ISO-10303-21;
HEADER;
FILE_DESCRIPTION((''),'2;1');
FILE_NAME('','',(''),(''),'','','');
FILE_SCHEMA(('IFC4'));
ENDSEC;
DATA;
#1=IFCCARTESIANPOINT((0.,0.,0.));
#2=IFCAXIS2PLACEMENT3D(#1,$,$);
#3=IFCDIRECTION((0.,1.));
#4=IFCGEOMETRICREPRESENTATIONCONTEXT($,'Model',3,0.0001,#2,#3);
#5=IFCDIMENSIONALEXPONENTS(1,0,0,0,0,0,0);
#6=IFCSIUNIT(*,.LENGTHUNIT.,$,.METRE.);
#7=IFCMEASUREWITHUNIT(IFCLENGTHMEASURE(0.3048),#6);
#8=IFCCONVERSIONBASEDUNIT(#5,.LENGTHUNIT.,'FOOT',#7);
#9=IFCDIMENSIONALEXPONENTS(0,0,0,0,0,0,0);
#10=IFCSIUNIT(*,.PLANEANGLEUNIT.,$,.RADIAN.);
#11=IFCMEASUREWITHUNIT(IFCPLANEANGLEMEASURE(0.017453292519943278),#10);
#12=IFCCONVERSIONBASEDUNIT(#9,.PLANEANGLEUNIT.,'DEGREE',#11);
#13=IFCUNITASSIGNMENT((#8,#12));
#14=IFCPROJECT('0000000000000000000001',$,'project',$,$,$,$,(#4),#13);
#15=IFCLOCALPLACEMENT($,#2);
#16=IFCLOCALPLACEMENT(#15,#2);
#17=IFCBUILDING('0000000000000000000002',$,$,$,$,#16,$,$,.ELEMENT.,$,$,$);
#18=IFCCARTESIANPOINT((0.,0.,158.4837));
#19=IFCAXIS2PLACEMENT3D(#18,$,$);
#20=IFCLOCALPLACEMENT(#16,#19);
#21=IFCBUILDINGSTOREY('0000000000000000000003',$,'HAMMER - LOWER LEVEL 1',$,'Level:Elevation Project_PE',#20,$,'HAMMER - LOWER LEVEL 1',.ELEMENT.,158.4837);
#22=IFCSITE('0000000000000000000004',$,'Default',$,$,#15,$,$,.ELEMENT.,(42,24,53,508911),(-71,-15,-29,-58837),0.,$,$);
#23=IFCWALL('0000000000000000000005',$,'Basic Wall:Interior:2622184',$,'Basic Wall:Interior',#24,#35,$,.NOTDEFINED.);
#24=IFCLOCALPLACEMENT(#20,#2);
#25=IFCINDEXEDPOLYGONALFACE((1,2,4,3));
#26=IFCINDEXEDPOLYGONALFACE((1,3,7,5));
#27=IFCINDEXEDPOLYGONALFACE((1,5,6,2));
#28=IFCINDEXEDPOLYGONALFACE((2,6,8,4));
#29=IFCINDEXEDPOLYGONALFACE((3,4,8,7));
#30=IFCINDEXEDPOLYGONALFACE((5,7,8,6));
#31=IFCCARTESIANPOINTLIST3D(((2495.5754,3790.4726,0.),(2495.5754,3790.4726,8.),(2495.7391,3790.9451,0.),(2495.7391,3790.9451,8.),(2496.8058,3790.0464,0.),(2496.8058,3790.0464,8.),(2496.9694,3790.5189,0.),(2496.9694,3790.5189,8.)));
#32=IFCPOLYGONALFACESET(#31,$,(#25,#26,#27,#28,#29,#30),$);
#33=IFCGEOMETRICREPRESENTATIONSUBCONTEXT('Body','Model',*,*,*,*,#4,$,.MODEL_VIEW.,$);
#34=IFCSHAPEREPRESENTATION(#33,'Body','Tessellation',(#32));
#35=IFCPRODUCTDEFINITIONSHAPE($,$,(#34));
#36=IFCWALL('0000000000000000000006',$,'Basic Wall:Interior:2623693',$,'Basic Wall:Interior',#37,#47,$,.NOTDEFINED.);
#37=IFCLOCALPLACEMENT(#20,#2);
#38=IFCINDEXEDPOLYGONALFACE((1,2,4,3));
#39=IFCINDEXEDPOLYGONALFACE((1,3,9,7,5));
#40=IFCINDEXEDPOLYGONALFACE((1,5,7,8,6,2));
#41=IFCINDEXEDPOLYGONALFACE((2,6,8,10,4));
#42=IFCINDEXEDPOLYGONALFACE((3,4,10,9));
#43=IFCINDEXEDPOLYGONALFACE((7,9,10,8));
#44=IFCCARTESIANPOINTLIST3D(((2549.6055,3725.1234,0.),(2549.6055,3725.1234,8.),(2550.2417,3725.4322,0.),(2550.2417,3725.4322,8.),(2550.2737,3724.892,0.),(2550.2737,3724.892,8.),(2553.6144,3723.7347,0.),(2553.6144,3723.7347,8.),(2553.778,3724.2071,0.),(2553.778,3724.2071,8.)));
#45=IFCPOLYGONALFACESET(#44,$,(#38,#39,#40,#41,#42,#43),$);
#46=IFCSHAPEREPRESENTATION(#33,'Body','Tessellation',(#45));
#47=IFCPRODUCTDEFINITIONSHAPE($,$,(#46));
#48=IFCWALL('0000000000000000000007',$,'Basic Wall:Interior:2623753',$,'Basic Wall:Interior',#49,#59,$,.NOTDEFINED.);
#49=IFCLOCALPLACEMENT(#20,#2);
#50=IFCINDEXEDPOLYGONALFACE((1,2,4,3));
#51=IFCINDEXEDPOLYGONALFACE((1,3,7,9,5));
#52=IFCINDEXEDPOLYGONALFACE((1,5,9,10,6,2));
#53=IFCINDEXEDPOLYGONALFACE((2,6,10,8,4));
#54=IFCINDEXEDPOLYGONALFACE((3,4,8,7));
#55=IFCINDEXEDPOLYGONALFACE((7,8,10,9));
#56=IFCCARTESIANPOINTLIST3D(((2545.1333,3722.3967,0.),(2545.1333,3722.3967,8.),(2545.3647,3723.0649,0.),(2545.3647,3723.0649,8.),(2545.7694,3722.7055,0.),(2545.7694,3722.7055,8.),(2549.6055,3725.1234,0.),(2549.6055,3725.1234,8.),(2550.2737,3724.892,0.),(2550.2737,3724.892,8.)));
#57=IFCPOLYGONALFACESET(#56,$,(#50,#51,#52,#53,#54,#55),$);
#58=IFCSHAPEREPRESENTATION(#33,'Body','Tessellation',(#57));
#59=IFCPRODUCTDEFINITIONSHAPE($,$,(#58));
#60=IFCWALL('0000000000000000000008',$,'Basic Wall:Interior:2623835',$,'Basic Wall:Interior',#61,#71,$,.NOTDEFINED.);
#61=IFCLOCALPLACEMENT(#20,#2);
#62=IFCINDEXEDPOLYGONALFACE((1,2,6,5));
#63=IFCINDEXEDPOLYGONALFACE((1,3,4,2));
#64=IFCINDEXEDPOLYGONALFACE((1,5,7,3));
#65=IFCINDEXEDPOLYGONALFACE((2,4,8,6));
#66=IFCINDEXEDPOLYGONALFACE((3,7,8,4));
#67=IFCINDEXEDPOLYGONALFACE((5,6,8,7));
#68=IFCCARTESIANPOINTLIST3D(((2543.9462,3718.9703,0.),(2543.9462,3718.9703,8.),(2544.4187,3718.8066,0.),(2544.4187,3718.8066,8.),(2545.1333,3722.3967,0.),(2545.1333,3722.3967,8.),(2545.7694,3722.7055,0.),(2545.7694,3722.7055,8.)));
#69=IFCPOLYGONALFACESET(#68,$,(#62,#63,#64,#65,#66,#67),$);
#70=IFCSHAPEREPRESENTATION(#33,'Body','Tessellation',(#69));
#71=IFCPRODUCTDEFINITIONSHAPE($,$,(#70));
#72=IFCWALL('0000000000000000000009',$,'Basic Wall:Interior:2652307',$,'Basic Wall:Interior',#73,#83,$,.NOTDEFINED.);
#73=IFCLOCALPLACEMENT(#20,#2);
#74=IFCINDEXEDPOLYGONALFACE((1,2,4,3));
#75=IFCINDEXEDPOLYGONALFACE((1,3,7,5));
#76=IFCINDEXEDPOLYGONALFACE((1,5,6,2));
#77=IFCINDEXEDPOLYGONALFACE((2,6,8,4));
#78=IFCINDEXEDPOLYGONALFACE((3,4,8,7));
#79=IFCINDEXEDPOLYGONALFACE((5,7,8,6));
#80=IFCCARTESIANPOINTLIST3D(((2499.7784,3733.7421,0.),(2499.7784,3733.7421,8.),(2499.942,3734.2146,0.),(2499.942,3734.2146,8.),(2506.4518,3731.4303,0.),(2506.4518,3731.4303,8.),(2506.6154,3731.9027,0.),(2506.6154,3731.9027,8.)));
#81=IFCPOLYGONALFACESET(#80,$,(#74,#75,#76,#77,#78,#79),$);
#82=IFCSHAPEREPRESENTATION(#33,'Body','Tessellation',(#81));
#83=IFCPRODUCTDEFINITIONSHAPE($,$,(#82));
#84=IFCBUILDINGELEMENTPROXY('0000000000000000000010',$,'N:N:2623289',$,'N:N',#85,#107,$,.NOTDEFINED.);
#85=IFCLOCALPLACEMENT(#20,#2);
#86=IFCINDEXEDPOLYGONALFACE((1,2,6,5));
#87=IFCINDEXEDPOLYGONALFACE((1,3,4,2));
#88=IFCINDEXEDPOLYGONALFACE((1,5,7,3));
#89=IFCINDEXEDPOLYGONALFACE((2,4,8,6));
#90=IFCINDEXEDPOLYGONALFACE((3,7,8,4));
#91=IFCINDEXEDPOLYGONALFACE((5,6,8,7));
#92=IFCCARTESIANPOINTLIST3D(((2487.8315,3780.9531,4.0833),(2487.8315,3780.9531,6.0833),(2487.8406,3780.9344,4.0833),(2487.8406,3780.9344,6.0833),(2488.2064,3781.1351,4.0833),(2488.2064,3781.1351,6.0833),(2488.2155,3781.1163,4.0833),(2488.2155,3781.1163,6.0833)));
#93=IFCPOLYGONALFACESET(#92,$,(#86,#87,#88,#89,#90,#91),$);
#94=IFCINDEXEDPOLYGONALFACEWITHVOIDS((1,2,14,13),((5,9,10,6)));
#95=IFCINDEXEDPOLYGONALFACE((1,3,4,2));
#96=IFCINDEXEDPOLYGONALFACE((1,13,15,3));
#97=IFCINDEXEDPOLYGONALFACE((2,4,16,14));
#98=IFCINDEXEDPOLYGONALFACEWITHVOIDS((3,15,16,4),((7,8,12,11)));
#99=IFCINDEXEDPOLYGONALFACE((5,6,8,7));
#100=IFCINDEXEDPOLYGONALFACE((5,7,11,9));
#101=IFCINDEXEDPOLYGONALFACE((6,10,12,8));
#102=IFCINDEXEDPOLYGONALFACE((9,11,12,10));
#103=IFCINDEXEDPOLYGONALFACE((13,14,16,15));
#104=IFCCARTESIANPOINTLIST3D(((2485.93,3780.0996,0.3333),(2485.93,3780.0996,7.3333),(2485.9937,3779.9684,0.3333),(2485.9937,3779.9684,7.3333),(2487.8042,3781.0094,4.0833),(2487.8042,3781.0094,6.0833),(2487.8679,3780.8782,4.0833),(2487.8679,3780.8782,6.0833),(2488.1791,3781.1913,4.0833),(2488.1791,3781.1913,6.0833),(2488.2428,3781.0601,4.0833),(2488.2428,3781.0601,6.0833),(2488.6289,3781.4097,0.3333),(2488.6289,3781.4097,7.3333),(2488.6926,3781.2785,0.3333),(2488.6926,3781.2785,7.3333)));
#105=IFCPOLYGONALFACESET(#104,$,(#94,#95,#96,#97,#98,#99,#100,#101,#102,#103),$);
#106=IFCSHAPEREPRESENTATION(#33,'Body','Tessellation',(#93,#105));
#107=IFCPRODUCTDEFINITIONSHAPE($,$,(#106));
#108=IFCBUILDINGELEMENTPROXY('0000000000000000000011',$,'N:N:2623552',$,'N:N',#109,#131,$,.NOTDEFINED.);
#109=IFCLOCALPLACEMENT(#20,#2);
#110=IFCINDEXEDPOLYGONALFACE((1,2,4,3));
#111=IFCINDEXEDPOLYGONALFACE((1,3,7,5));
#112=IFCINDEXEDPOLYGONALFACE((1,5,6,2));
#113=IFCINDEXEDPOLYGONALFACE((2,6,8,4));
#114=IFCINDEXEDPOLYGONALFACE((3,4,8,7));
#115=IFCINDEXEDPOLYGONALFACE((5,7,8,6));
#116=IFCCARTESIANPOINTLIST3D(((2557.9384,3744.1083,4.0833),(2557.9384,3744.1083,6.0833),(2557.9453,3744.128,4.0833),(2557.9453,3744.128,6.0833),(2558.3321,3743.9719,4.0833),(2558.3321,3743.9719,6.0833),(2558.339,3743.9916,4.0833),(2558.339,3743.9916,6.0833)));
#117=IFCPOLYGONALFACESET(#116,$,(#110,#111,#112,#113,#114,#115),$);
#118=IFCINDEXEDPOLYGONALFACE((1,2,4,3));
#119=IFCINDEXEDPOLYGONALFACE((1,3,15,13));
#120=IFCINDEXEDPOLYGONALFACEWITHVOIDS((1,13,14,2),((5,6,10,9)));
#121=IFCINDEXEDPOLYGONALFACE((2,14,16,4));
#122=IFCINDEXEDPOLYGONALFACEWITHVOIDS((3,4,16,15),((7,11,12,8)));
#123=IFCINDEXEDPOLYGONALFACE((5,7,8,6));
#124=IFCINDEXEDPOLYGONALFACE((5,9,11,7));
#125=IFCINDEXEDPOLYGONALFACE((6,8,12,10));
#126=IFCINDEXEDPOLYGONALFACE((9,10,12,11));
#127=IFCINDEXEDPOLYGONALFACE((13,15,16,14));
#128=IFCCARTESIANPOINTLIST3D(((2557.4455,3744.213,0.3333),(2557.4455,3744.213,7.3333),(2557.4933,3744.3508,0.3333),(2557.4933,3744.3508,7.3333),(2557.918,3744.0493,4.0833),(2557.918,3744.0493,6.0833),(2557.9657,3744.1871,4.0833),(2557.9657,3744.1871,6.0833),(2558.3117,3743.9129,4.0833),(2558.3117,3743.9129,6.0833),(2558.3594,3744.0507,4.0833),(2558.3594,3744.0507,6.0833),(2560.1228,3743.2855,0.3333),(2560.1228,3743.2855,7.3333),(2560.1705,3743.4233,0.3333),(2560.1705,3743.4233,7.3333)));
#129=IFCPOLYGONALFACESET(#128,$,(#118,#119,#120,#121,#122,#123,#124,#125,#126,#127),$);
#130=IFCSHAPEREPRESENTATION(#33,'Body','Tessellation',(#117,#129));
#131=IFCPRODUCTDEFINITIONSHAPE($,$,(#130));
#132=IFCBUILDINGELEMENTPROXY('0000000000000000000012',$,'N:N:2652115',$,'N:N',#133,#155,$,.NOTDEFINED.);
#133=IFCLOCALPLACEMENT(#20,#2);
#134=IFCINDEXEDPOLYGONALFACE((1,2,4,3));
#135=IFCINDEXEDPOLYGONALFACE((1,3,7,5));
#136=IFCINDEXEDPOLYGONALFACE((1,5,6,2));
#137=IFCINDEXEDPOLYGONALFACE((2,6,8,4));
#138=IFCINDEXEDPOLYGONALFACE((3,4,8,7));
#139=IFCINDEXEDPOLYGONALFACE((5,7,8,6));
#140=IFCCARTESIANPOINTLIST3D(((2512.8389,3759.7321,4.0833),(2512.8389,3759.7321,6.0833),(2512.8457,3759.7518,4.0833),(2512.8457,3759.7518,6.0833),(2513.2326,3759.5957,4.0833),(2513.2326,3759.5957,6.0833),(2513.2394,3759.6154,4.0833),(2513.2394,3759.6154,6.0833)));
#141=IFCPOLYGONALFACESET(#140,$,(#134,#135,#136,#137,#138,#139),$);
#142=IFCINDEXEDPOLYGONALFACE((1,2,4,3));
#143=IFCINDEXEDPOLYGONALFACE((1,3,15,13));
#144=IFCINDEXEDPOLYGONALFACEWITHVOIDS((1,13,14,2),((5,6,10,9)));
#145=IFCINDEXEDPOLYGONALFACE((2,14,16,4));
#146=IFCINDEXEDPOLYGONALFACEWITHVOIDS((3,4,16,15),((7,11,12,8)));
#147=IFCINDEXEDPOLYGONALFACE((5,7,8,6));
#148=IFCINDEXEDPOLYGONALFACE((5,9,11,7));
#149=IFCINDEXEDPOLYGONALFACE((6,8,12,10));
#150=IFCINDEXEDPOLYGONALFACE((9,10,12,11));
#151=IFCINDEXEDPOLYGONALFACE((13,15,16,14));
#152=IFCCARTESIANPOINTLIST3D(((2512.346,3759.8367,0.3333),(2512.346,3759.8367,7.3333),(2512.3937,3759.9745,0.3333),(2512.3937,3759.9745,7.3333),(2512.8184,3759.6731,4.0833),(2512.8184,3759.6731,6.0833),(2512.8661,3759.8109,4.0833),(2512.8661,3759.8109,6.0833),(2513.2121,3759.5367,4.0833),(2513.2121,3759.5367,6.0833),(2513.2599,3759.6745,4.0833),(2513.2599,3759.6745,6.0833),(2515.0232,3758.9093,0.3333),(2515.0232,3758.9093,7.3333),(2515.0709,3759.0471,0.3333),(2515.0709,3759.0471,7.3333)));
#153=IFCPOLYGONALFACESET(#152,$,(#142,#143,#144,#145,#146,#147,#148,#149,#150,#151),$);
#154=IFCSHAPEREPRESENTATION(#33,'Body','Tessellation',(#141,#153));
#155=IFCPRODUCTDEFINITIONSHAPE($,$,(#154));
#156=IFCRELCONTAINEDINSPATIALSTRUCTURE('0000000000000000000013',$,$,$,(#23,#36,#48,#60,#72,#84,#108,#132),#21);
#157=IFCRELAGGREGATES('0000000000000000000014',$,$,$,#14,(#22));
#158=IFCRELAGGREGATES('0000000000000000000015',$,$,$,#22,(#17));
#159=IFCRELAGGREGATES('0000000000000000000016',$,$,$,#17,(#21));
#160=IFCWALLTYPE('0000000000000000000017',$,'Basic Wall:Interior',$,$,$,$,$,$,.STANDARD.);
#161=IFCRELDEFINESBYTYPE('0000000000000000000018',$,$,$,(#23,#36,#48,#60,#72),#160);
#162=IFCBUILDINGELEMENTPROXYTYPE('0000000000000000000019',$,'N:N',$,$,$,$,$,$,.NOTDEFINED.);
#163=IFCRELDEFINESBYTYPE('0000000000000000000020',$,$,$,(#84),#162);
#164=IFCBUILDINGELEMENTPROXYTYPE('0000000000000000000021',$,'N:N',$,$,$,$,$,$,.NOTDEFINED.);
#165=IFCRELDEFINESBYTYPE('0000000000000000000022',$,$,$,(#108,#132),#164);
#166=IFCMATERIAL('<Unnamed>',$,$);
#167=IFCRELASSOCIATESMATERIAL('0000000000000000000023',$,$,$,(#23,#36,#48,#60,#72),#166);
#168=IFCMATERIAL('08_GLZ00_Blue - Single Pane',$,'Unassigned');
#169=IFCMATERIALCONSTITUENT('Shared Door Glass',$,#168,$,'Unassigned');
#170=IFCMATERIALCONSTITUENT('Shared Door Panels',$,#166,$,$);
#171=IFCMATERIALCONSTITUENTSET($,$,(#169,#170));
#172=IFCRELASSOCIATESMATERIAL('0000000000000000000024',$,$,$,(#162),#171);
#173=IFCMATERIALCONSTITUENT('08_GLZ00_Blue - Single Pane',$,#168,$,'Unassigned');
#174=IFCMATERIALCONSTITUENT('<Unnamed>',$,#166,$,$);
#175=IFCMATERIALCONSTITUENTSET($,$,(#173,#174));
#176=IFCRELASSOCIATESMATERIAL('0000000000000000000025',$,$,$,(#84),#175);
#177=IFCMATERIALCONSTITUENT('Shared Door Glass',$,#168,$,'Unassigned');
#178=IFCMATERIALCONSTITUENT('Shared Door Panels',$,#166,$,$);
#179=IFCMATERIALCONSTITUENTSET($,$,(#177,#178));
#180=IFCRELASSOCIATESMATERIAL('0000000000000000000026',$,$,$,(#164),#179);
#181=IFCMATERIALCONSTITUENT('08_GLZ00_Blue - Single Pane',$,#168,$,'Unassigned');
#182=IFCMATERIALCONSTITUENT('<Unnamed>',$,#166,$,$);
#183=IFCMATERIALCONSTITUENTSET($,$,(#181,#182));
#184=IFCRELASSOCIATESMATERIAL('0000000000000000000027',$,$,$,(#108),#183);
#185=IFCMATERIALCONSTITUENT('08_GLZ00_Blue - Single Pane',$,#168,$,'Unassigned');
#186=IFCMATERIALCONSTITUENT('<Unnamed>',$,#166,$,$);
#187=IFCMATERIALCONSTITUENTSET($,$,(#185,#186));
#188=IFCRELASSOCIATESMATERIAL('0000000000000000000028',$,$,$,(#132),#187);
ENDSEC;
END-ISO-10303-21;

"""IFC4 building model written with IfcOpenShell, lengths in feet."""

from ifc_helpers import new_model, entity, si_unit, converted_unit, direction, frame, origin, place, context, subcontext, project, spatial, indexed_curve, outline, extrude, source, transform, mapped, material, constituent, constituent_set, type_object, type_shapes, element, save


model = new_model("IFC4")

# Units and contexts
model_context = context("Model", 3, precision=0.0001, world=origin(), true_north=direction((0.0, 1.0)))
body_context = subcontext(model_context, "Body", "Model", "MODEL_VIEW")
ifc_project = project(units=[converted_unit("LENGTHUNIT", "FOOT", entity("IfcLengthMeasure", 0.3048), si_unit("LENGTHUNIT", "METRE"), dimensions=[1, 0, 0, 0, 0, 0, 0]), converted_unit("PLANEANGLEUNIT", "DEGREE", entity("IfcPlaneAngleMeasure", 0.017453292519943278), si_unit("PLANEANGLEUNIT", "RADIAN"), dimensions=[0, 0, 0, 0, 0, 0, 0])], contexts=[model_context])

# Site, building, storey
site_placement = place(None, origin())
site = spatial("IfcSite", under=ifc_project, at=site_placement, Name="Default", CompositionType="ELEMENT", RefLatitude=(42, 24, 53, 508911), RefLongitude=(-71, -15, -29, -58837), RefElevation=0.0)
building_placement = place(site_placement, origin())
building = spatial("IfcBuilding", under=site, at=building_placement, CompositionType="ELEMENT")
storey_placement = place(building_placement, frame((0.0, 0.0, 158.4837)))
storey = spatial("IfcBuildingStorey", under=building, at=storey_placement, Name="HAMMER - LOWER LEVEL 1", ObjectType="Level:Elevation Project_PE", LongName="HAMMER - LOWER LEVEL 1", CompositionType="ELEMENT", Elevation=158.4837)

# Walls
ifc_material_1 = material(Name="<Unnamed>")
wall_type = type_object("IfcWallType", Name="Basic Wall:Interior", PredefinedType="STANDARD")
wall_1_placement = place(storey_placement, frame((2495.6573, 3790.7089, 0.0), z_axis=(0.0, 0.0, 1.0), x_axis=(0.944906, -0.327342, 0.0)))
element("IfcWall", 1, at=wall_1_placement, inside=storey, type_object=wall_type, material=ifc_material_1, Name="Basic Wall:Interior:2622184", ObjectType="Basic Wall:Interior", PredefinedType="NOTDEFINED", context=body_context, shape_type="SweptSolid", body=[
    extrude(outline(indexed_curve([(1.3021, 0.25), (0.0, 0.25), (0.0, -0.25), (1.3021, -0.25), (1.3021, 0.25)], self_intersect=False)), origin(), (0.0, 0.0, 1.0), 8.0),
])
wall_2_placement = place(storey_placement, frame((2553.6962, 3723.9709, 0.0), z_axis=(0.0, 0.0, 1.0), x_axis=(-0.944906, 0.327342, 0.0)))
element("IfcWall", 2, at=wall_2_placement, inside=storey, type_object=wall_type, material=ifc_material_1, Name="Basic Wall:Interior:2623693", ObjectType="Basic Wall:Interior", PredefinedType="NOTDEFINED", context=body_context, shape_type="SweptSolid", body=[
    extrude(outline(indexed_curve([(3.7426, -0.25), (4.2426, 0.25), (3.5355, 0.25), (0.0, 0.25), (0.0, -0.25), (3.7426, -0.25)], self_intersect=False)), origin(), (0.0, 0.0, 1.0), 8.0),
])
wall_3_placement = place(storey_placement, frame((2550.1645, 3725.1169, 0.0), z_axis=(0.0, 0.0, 1.0), x_axis=(-0.899615, -0.436683, 0.0)))
element("IfcWall", 3, at=wall_3_placement, inside=storey, type_object=wall_type, material=ifc_material_1, Name="Basic Wall:Interior:2623753", ObjectType="Basic Wall:Interior", PredefinedType="NOTDEFINED", context=body_context, shape_type="SweptSolid", body=[
    extrude(outline(indexed_curve([(5.214, -0.25), (5.714, 0.25), (5.0069, 0.25), (0.0, 0.25), (0.5, -0.25), (5.214, -0.25)], self_intersect=False)), origin(), (0.0, 0.0, 1.0), 8.0),
])
wall_4_placement = place(storey_placement, frame((2545.5332, 3722.7873, 0.0), z_axis=(0.0, 0.0, 1.0), x_axis=(-0.327342, -0.944906, 0.0)))
element("IfcWall", 4, at=wall_4_placement, inside=storey, type_object=wall_type, material=ifc_material_1, Name="Basic Wall:Interior:2623835", ObjectType="Basic Wall:Interior", PredefinedType="NOTDEFINED", context=body_context, shape_type="SweptSolid", body=[
    extrude(outline(indexed_curve([(4.1262, -0.25), (4.1262, 0.25), (0.0, 0.25), (0.5, -0.25), (4.1262, -0.25)], self_intersect=False)), origin(), (0.0, 0.0, 1.0), 8.0),
])
wall_5_placement = place(storey_placement, frame((2506.5336, 3731.6665, 0.0), z_axis=(0.0, 0.0, 1.0), x_axis=(-0.944906, 0.327342, 0.0)))
element("IfcWall", 5, at=wall_5_placement, inside=storey, type_object=wall_type, material=ifc_material_1, Name="Basic Wall:Interior:2652307", ObjectType="Basic Wall:Interior", PredefinedType="NOTDEFINED", context=body_context, shape_type="SweptSolid", body=[
    extrude(outline(indexed_curve([(7.0625, 0.25), (0.0, 0.25), (0.0, -0.25), (7.0625, -0.25), (7.0625, 0.25)], self_intersect=False)), origin(), (0.0, 0.0, 1.0), 8.0),
])

# Building element proxies
ifc_material_2 = material(Name="08_GLZ00_Blue - Single Pane", Category="Unassigned")
ifc_constituent_1 = constituent(ifc_material_2, Name="08_GLZ00_Blue - Single Pane", Category="Unassigned")
ifc_constituent_2 = constituent(ifc_material_1, Name="<Unnamed>")
ifc_constituent_set_1 = constituent_set(constituents=[ifc_constituent_1, ifc_constituent_2])
ifc_constituent_3 = constituent(ifc_material_2, Name="Shared Door Glass", Category="Unassigned")
ifc_constituent_4 = constituent(ifc_material_1, Name="Shared Door Panels")
ifc_constituent_set_2 = constituent_set(constituents=[ifc_constituent_3, ifc_constituent_4])
building_element_proxy_type_1 = type_object("IfcBuildingElementProxyType", Name="N:N", PredefinedType="NOTDEFINED", material=ifc_constituent_set_2)
shared_shape_1 = source(origin(), body_context, "Body", "SweptSolid", [
    extrude(outline(indexed_curve([(-0.2083, -0.0104), (0.2083, -0.0104), (0.2083, 0.0104), (-0.2083, 0.0104), (-0.2083, -0.0104)], self_intersect=False)), frame((-1.0775, -3.25, 3.75), z_axis=(0.0, 0.0, 1.0), x_axis=(-1.0, 0.0, 0.0)), (0.0, 0.0, 1.0), 2.0),
    extrude(outline(indexed_curve([(-3.5, -1.5), (3.5, -1.5), (3.5, 1.5), (-3.5, 1.5), (-3.5, -1.5)], self_intersect=False), holes=[indexed_curve([(-2.25, 0.5833), (-2.25, 1.0), (-0.25, 1.0), (-0.25, 0.5833), (-2.25, 0.5833)], self_intersect=False)]), frame((-0.2859, -3.3229, 3.5), z_axis=(0.0, 1.0, 0.0), x_axis=(0.0, 0.0, -1.0)), (0.0, 0.0, 1.0), 0.1458),
])
type_shapes(building_element_proxy_type_1, [shared_shape_1])
proxy_1_placement = place(storey_placement, frame((2488.4733, 3777.6404, 0.3333), z_axis=(0.0, 0.0, 1.0), x_axis=(-0.899615, -0.436683, 0.0)))
element("IfcBuildingElementProxy", 6, at=proxy_1_placement, inside=storey, type_object=building_element_proxy_type_1, material=ifc_constituent_set_1, Name="N:N:2623289", ObjectType="N:N", PredefinedType="NOTDEFINED", context=body_context, shape_type="MappedRepresentation", body=[
    mapped(shared_shape_1, transform((0.0, 0.0, 0.0), scale=1.0)),
])
ifc_constituent_5 = constituent(ifc_material_2, Name="08_GLZ00_Blue - Single Pane", Category="Unassigned")
ifc_constituent_6 = constituent(ifc_material_1, Name="<Unnamed>")
ifc_constituent_set_3 = constituent_set(constituents=[ifc_constituent_5, ifc_constituent_6])
ifc_constituent_7 = constituent(ifc_material_2, Name="Shared Door Glass", Category="Unassigned")
ifc_constituent_8 = constituent(ifc_material_1, Name="Shared Door Panels")
ifc_constituent_set_4 = constituent_set(constituents=[ifc_constituent_7, ifc_constituent_8])
building_element_proxy_type_2 = type_object("IfcBuildingElementProxyType", Name="N:N", PredefinedType="NOTDEFINED", material=ifc_constituent_set_4)
shared_shape_2 = source(origin(), body_context, "Body", "SweptSolid", [
    extrude(outline(indexed_curve([(-0.0104, -0.2083), (0.0104, -0.2083), (0.0104, 0.2083), (-0.0104, 0.2083), (-0.0104, -0.2083)], self_intersect=False)), frame((-0.9942, 3.25, 3.75), z_axis=(0.0, 0.0, 1.0), x_axis=(0.0, 1.0, 0.0)), (0.0, 0.0, 1.0), 2.0),
    extrude(outline(indexed_curve([(-3.5, -1.4167), (3.5, -1.4167), (3.5, 1.4167), (-3.5, 1.4167), (-3.5, -1.4167)], self_intersect=False), holes=[indexed_curve([(-2.25, 0.5), (-2.25, 0.9167), (-0.25, 0.9167), (-0.25, 0.5), (-2.25, 0.5)], self_intersect=False)]), frame((-0.2859, 3.1771, 3.5), z_axis=(0.0, 1.0, 0.0), x_axis=(0.0, 0.0, -1.0)), (0.0, 0.0, 1.0), 0.1458),
])
type_shapes(building_element_proxy_type_2, [shared_shape_2])
proxy_2_placement = place(storey_placement, frame((2558.0143, 3740.6536, 0.3333), z_axis=(0.0, 0.0, 1.0), x_axis=(0.944906, -0.327342, 0.0)))
element("IfcBuildingElementProxy", 7, at=proxy_2_placement, inside=storey, type_object=building_element_proxy_type_2, material=ifc_constituent_set_3, Name="N:N:2623552", ObjectType="N:N", PredefinedType="NOTDEFINED", context=body_context, shape_type="MappedRepresentation", body=[
    mapped(shared_shape_2, transform((0.0, 0.0, 0.0), scale=1.0)),
])
ifc_constituent_9 = constituent(ifc_material_2, Name="08_GLZ00_Blue - Single Pane", Category="Unassigned")
ifc_constituent_10 = constituent(ifc_material_1, Name="<Unnamed>")
ifc_constituent_set_5 = constituent_set(constituents=[ifc_constituent_9, ifc_constituent_10])
proxy_3_placement = place(storey_placement, frame((2512.9147, 3756.2774, 0.3333), z_axis=(0.0, 0.0, 1.0), x_axis=(0.944906, -0.327342, 0.0)))
element("IfcBuildingElementProxy", 8, at=proxy_3_placement, inside=storey, type_object=building_element_proxy_type_2, material=ifc_constituent_set_5, Name="N:N:2652115", ObjectType="N:N", PredefinedType="NOTDEFINED", context=body_context, shape_type="MappedRepresentation", body=[
    mapped(shared_shape_2, transform((0.0, 0.0, 0.0), scale=1.0)),
])

save(model, "model.ifc")
